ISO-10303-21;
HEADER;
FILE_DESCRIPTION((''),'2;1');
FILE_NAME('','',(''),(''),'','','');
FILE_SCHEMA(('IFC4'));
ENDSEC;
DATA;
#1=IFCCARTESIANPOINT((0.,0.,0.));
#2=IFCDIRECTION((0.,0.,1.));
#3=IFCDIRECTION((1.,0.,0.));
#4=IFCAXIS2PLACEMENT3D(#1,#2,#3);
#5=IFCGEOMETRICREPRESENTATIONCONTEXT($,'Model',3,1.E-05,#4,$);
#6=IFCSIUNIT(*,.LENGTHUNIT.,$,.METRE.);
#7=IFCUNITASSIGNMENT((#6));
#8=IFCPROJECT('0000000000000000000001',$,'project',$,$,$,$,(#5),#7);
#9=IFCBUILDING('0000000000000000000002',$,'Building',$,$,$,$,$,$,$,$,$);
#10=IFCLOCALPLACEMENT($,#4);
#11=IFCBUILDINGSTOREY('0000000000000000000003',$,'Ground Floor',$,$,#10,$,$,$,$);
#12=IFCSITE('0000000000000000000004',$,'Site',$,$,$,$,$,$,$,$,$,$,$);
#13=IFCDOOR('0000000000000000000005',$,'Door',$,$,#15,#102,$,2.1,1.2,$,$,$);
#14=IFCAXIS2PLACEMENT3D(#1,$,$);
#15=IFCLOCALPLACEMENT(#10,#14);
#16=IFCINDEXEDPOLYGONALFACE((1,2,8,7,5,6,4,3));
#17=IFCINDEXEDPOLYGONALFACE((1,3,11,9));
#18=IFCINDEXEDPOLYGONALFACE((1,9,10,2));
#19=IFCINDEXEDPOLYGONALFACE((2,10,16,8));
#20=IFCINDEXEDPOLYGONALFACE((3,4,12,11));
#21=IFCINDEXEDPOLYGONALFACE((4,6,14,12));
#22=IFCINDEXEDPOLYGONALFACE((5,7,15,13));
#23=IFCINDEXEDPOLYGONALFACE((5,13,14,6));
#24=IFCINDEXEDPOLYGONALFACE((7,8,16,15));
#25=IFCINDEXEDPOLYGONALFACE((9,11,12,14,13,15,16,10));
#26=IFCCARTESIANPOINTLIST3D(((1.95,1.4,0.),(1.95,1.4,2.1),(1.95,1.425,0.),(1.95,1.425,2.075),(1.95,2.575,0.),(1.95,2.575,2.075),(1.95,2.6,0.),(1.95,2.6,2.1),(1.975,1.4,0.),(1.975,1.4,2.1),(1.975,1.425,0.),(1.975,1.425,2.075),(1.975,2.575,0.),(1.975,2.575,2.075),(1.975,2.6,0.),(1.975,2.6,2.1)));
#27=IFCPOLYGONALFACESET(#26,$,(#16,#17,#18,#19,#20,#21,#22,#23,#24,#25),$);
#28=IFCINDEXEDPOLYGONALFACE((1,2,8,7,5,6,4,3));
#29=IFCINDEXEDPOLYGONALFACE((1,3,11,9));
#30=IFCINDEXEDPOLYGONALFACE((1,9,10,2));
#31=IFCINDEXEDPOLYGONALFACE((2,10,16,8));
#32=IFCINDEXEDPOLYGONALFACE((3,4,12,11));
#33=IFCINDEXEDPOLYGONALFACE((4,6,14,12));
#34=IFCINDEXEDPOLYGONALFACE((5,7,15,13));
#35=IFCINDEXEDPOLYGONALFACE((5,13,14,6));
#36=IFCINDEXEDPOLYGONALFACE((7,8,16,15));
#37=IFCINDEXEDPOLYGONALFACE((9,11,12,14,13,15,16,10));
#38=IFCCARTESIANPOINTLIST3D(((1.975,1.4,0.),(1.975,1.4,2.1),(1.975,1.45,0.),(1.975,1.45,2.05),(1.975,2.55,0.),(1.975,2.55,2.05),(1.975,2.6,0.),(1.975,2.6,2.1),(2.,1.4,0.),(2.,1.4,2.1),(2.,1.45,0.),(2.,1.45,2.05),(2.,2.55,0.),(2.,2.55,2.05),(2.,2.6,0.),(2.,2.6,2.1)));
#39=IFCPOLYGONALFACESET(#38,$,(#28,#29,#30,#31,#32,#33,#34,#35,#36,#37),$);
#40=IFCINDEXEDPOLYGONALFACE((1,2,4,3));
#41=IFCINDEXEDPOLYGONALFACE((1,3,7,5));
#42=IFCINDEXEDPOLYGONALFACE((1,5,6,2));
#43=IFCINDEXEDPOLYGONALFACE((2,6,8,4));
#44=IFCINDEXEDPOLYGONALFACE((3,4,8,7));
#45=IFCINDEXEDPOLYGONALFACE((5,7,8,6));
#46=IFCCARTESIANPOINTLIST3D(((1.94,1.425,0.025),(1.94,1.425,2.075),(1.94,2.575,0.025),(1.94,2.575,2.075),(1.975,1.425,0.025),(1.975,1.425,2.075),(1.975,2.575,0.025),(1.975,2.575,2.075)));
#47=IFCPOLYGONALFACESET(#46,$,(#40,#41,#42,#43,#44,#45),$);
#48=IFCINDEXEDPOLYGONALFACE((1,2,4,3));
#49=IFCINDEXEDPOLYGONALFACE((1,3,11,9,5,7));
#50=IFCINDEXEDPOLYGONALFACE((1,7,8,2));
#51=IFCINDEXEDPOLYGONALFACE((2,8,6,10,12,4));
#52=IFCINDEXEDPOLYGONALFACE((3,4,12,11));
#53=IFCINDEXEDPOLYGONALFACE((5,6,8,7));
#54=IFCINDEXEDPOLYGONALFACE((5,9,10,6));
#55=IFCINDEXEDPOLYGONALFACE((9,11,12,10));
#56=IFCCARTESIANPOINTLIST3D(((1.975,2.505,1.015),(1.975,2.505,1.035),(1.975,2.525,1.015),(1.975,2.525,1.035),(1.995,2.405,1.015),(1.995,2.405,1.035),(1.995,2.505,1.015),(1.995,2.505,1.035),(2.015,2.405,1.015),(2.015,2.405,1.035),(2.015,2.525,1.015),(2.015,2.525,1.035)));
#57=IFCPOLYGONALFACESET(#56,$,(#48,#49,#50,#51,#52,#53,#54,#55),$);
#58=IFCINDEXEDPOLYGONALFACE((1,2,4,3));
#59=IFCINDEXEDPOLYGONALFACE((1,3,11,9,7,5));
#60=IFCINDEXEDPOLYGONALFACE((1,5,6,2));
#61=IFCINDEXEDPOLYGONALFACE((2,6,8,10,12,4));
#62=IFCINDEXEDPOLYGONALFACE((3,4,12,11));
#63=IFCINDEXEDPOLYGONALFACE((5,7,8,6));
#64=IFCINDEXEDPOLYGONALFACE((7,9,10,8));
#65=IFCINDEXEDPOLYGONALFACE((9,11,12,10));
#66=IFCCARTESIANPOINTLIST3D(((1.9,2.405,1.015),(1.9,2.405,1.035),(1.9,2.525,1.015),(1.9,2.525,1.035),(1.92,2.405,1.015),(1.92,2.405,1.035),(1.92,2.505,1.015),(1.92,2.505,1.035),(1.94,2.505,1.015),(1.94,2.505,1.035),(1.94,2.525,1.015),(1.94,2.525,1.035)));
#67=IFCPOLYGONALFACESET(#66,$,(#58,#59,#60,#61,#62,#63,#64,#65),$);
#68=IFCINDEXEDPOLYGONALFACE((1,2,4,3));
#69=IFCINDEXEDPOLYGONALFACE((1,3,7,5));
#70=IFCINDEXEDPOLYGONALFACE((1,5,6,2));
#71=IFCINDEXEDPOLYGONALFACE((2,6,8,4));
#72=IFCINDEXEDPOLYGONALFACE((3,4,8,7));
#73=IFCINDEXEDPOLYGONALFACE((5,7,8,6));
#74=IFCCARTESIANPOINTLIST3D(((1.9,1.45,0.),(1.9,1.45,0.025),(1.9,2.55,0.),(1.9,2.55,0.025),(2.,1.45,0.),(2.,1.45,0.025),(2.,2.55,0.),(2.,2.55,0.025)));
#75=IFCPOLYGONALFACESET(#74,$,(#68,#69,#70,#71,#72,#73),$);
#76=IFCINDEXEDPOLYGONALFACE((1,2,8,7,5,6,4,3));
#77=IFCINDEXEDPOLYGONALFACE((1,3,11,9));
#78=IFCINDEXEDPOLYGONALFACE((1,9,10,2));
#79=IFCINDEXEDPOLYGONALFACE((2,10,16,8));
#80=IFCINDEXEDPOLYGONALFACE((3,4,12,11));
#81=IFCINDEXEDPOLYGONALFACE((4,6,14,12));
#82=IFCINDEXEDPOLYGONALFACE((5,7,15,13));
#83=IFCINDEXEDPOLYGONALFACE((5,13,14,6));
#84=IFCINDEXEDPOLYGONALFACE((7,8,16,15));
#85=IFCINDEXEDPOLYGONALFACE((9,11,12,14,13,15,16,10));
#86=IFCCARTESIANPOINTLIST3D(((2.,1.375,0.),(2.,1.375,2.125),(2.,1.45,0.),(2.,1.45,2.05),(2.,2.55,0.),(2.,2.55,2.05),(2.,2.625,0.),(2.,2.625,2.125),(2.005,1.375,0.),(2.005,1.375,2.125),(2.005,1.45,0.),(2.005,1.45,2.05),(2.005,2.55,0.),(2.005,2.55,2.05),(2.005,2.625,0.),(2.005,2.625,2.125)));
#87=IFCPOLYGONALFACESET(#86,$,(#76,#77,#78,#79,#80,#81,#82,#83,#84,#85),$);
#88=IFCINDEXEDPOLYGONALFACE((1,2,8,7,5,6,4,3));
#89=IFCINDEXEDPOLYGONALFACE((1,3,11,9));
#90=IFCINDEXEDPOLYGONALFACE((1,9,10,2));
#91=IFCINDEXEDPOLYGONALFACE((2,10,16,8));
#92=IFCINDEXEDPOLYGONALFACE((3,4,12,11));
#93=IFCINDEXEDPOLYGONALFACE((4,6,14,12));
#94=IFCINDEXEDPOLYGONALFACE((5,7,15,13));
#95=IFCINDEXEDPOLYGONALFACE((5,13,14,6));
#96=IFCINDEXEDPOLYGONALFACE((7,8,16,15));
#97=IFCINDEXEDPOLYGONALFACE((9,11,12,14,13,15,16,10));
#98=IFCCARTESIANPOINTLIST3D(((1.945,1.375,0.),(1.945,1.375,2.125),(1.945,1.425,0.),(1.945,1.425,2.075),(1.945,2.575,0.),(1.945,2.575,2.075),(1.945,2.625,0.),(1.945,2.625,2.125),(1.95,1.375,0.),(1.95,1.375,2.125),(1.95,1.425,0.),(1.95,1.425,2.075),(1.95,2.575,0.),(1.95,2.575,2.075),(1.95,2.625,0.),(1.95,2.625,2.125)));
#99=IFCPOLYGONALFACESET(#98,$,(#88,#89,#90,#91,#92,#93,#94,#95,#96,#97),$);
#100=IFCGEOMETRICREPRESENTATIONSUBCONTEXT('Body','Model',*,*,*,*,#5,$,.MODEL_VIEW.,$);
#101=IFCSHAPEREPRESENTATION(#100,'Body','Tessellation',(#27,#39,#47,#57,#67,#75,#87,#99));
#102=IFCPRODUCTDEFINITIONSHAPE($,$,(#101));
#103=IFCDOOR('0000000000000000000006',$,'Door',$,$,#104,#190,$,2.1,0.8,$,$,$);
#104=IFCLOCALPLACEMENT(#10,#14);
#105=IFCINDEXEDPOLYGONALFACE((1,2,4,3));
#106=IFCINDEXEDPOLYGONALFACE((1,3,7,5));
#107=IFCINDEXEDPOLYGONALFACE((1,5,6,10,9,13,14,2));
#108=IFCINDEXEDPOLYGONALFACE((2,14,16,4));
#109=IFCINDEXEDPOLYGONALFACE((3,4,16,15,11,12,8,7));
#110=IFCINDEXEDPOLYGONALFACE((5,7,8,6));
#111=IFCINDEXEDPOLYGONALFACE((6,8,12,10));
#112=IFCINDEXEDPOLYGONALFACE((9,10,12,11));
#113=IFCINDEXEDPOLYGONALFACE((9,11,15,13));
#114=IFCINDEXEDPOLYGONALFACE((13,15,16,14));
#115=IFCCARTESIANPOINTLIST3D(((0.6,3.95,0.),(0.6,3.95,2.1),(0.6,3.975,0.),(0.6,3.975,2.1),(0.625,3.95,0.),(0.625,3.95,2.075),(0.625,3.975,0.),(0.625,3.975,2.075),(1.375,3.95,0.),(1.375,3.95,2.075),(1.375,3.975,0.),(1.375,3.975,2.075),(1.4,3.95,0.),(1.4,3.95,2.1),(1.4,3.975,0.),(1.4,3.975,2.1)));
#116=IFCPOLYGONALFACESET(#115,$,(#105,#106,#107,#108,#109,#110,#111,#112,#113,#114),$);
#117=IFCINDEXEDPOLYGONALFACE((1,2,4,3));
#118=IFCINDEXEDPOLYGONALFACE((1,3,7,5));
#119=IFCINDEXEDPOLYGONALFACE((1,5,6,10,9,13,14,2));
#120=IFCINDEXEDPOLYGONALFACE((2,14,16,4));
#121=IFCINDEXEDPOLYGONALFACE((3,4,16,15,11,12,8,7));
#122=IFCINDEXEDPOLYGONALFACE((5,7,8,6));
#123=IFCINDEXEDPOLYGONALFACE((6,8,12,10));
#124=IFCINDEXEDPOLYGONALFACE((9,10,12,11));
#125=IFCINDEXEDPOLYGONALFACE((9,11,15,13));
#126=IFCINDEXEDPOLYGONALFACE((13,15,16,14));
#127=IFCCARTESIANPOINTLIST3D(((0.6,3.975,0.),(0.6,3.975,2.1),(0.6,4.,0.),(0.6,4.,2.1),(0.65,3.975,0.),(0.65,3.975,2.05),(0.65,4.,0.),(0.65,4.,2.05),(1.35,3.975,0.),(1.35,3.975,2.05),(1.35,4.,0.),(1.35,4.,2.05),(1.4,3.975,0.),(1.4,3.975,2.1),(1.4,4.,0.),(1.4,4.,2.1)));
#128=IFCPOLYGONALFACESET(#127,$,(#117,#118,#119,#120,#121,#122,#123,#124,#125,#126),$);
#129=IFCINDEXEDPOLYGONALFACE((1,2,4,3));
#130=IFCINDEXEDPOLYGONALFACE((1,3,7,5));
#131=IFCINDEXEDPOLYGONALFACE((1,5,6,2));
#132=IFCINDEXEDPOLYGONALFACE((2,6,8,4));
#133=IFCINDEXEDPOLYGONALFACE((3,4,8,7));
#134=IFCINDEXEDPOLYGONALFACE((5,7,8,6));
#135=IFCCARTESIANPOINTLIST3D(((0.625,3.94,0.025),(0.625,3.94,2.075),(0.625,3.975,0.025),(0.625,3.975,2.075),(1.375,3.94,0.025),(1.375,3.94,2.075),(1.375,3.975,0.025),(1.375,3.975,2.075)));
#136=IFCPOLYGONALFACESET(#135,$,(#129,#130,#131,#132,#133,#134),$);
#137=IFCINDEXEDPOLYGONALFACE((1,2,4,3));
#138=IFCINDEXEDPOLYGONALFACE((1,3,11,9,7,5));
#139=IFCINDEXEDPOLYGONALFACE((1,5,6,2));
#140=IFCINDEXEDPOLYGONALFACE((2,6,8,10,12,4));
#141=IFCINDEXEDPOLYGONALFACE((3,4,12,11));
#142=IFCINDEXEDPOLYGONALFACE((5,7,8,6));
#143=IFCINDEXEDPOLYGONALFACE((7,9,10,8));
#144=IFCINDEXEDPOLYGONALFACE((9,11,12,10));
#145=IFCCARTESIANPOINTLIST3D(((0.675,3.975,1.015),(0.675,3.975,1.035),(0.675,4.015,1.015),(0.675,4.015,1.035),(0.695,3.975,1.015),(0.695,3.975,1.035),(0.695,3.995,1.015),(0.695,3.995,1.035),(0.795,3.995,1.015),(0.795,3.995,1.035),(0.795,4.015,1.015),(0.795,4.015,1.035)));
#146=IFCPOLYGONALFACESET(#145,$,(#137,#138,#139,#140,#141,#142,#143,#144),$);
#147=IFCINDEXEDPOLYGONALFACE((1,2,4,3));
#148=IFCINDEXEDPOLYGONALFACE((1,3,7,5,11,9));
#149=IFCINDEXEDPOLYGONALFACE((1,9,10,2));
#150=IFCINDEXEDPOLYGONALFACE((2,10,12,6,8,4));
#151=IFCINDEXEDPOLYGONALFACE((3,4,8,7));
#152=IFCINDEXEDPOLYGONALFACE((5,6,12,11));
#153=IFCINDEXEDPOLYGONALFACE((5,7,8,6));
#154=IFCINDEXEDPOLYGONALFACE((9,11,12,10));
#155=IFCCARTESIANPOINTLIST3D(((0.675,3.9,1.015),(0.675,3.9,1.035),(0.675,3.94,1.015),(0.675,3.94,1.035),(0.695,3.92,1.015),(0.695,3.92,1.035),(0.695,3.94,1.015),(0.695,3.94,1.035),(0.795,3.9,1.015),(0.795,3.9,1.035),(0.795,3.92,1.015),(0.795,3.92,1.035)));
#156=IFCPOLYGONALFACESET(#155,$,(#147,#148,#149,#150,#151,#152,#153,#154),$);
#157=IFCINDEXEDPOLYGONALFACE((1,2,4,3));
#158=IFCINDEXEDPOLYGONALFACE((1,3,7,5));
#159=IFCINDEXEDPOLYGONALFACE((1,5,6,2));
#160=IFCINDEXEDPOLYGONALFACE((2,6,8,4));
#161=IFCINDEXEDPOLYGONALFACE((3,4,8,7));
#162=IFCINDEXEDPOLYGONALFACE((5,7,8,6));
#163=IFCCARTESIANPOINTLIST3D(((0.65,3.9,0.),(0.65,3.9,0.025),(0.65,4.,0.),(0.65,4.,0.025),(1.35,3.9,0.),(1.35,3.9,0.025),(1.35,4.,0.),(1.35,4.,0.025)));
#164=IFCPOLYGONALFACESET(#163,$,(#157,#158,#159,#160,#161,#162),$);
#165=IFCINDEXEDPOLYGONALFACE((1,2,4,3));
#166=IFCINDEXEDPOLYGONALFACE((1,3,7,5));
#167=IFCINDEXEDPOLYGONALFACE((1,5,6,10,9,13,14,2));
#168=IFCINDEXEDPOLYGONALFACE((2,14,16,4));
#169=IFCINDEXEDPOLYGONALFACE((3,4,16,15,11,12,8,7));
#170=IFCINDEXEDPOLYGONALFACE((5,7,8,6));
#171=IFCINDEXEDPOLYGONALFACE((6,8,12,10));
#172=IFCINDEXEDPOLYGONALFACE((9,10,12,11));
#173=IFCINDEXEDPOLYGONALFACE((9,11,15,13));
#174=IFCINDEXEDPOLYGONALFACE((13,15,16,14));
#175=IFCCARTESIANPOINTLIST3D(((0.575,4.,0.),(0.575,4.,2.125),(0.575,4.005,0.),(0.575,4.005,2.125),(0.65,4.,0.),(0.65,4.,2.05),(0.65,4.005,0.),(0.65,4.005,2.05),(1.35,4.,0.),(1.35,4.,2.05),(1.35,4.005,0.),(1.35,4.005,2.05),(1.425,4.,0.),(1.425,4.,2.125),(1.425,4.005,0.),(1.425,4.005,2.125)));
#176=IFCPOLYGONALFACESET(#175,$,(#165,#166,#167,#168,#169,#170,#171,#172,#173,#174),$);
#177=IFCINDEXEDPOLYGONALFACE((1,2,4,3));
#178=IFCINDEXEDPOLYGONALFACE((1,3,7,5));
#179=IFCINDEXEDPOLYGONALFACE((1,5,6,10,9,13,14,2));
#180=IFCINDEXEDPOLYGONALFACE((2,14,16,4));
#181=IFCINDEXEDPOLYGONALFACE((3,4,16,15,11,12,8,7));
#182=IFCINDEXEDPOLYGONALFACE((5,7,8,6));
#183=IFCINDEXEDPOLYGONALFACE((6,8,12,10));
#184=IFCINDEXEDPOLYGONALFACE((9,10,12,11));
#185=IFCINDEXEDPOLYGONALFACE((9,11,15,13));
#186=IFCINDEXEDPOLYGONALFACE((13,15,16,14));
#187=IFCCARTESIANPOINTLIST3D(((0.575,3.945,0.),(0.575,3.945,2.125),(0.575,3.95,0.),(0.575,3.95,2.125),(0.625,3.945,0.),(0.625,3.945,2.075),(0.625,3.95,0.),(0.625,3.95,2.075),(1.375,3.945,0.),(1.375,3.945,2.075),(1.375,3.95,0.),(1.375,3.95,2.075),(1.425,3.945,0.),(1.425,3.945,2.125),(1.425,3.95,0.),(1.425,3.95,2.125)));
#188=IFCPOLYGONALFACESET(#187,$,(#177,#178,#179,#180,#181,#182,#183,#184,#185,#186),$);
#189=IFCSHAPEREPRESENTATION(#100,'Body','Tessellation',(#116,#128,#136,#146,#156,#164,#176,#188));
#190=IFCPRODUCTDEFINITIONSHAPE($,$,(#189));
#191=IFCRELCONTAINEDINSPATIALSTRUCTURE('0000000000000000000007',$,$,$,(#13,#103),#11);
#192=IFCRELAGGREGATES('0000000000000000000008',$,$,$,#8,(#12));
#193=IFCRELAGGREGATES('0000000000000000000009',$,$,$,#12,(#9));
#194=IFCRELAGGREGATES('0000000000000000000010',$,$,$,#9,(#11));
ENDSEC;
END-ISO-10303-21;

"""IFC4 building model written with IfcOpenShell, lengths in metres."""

from ifc_helpers import new_model, si_unit, frame, origin_with_axes, place, context, subcontext, project, spatial, line, indexed_curve, outline, extrude, element, save


model = new_model("IFC4")

# Units and contexts
model_context = context("Model", 3, precision=1e-05, world=origin_with_axes())
body_context = subcontext(model_context, "Body", "Model", "MODEL_VIEW")
ifc_project = project(units=[si_unit("LENGTHUNIT", "METRE")], contexts=[model_context])

# Site, building, storey
site = spatial("IfcSite", under=ifc_project, Name="Site")
building = spatial("IfcBuilding", under=site, Name="Building")
storey_placement = place(None, origin_with_axes())
storey = spatial("IfcBuildingStorey", under=building, at=storey_placement, Name="Ground Floor")

# Doors
door_1_placement = place(storey_placement, frame((2.0, 1.4, 0.0), z_axis=(0.0, 0.0, 1.0), x_axis=(0.0, 1.0, 0.0)))
element("IfcDoor", 1, at=door_1_placement, inside=storey, Name="Door", OverallHeight=2.1, OverallWidth=1.2, context=body_context, shape_type="SweptSolid", body=[
    extrude(outline(indexed_curve([(0.0, 0.0), (0.0, 2.1), (1.2, 2.1), (1.2, 0.0), (1.175, 0.0), (1.175, 2.075), (0.025, 2.075), (0.025, 0.0)], segments=[line(1, 2, 3, 4, 5, 6, 7, 8, 1)])), frame((0.0, 0.025, 0.0), z_axis=(0.0, -1.0, 0.0), x_axis=(1.0, 0.0, 0.0)), (0.0, 0.0, -1.0), 0.025),
    extrude(outline(indexed_curve([(0.0, 0.0), (0.0, 2.1), (1.2, 2.1), (1.2, 0.0), (1.15, 0.0), (1.15, 2.05), (0.05, 2.05), (0.05, 0.0)], segments=[line(1, 2, 3, 4, 5, 6, 7, 8, 1)])), frame((0.0, 0.0, 0.0), z_axis=(0.0, -1.0, 0.0), x_axis=(1.0, 0.0, 0.0)), (0.0, 0.0, -1.0), 0.025),
    extrude(outline(indexed_curve([(0.0, 0.0), (1.15, 0.0), (1.15, 0.035), (0.0, 0.035)], segments=[line(1, 2, 3, 4, 1)])), frame((0.025, 0.025, 0.025), z_axis=(0.0, 0.0, 1.0), x_axis=(1.0, 0.0, 0.0)), (0.0, 0.0, 1.0), 2.05),
    extrude(outline(indexed_curve([(0.0, 0.0), (0.0, -0.04), (-0.12, -0.04), (-0.12, -0.02), (-0.02, -0.02), (-0.02, 0.0)], segments=[line(1, 2, 3, 4, 5, 6, 1)])), frame((1.125, 0.025, 1.015), z_axis=(0.0, 0.0, 1.0), x_axis=(1.0, 0.0, 0.0)), (0.0, 0.0, 1.0), 0.02),
    extrude(outline(indexed_curve([(0.0, 0.0), (0.0, 0.04), (-0.12, 0.04), (-0.12, 0.02), (-0.02, 0.02), (-0.02, 0.0)], segments=[line(1, 2, 3, 4, 5, 6, 1)])), frame((1.125, 0.06, 1.015), z_axis=(0.0, 0.0, 1.0), x_axis=(1.0, 0.0, 0.0)), (0.0, 0.0, 1.0), 0.02),
    extrude(outline(indexed_curve([(0.0, 0.0), (1.1, 0.0), (1.1, 0.1), (0.0, 0.1)], segments=[line(1, 2, 3, 4, 1)])), frame((0.05, 0.0, 0.0), z_axis=(0.0, 0.0, 1.0), x_axis=(1.0, 0.0, 0.0)), (0.0, 0.0, 1.0), 0.025),
    extrude(outline(indexed_curve([(0.0, 0.0), (0.0, 2.125), (1.25, 2.125), (1.25, 0.0), (1.175, 0.0), (1.175, 2.05), (0.075, 2.05), (0.075, 0.0)], segments=[line(1, 2, 3, 4, 5, 6, 7, 8, 1)])), frame((-0.025, -0.005, 0.0), z_axis=(0.0, -1.0, 0.0), x_axis=(1.0, 0.0, 0.0)), (0.0, 0.0, -1.0), 0.005),
    extrude(outline(indexed_curve([(0.0, 0.0), (0.0, 2.125), (1.25, 2.125), (1.25, 0.0), (1.2, 0.0), (1.2, 2.075), (0.05, 2.075), (0.05, 0.0)], segments=[line(1, 2, 3, 4, 5, 6, 7, 8, 1)])), frame((-0.025, 0.05, 0.0), z_axis=(0.0, -1.0, 0.0), x_axis=(1.0, 0.0, 0.0)), (0.0, 0.0, -1.0), 0.005),
])
door_2_placement = place(storey_placement, frame((1.4, 4.0, 0.0), z_axis=(0.0, 0.0, 1.0), x_axis=(-1.0, 0.0, 0.0)))
element("IfcDoor", 2, at=door_2_placement, inside=storey, Name="Door", OverallHeight=2.1, OverallWidth=0.8, context=body_context, shape_type="SweptSolid", body=[
    extrude(outline(indexed_curve([(0.0, 0.0), (0.0, 2.1), (0.8, 2.1), (0.8, 0.0), (0.775, 0.0), (0.775, 2.075), (0.025, 2.075), (0.025, 0.0)], segments=[line(1, 2, 3, 4, 5, 6, 7, 8, 1)])), frame((0.0, 0.025, 0.0), z_axis=(0.0, -1.0, 0.0), x_axis=(1.0, 0.0, 0.0)), (0.0, 0.0, -1.0), 0.025),
    extrude(outline(indexed_curve([(0.0, 0.0), (0.0, 2.1), (0.8, 2.1), (0.8, 0.0), (0.75, 0.0), (0.75, 2.05), (0.05, 2.05), (0.05, 0.0)], segments=[line(1, 2, 3, 4, 5, 6, 7, 8, 1)])), frame((0.0, 0.0, 0.0), z_axis=(0.0, -1.0, 0.0), x_axis=(1.0, 0.0, 0.0)), (0.0, 0.0, -1.0), 0.025),
    extrude(outline(indexed_curve([(0.0, 0.0), (0.75, 0.0), (0.75, 0.035), (0.0, 0.035)], segments=[line(1, 2, 3, 4, 1)])), frame((0.025, 0.025, 0.025), z_axis=(0.0, 0.0, 1.0), x_axis=(1.0, 0.0, 0.0)), (0.0, 0.0, 1.0), 2.05),
    extrude(outline(indexed_curve([(0.0, 0.0), (0.0, -0.04), (-0.12, -0.04), (-0.12, -0.02), (-0.02, -0.02), (-0.02, 0.0)], segments=[line(1, 2, 3, 4, 5, 6, 1)])), frame((0.725, 0.025, 1.015), z_axis=(0.0, 0.0, 1.0), x_axis=(1.0, 0.0, 0.0)), (0.0, 0.0, 1.0), 0.02),
    extrude(outline(indexed_curve([(0.0, 0.0), (0.0, 0.04), (-0.12, 0.04), (-0.12, 0.02), (-0.02, 0.02), (-0.02, 0.0)], segments=[line(1, 2, 3, 4, 5, 6, 1)])), frame((0.725, 0.06, 1.015), z_axis=(0.0, 0.0, 1.0), x_axis=(1.0, 0.0, 0.0)), (0.0, 0.0, 1.0), 0.02),
    extrude(outline(indexed_curve([(0.0, 0.0), (0.7, 0.0), (0.7, 0.1), (0.0, 0.1)], segments=[line(1, 2, 3, 4, 1)])), frame((0.05, 0.0, 0.0), z_axis=(0.0, 0.0, 1.0), x_axis=(1.0, 0.0, 0.0)), (0.0, 0.0, 1.0), 0.025),
    extrude(outline(indexed_curve([(0.0, 0.0), (0.0, 2.125), (0.85, 2.125), (0.85, 0.0), (0.775, 0.0), (0.775, 2.05), (0.075, 2.05), (0.075, 0.0)], segments=[line(1, 2, 3, 4, 5, 6, 7, 8, 1)])), frame((-0.025, -0.005, 0.0), z_axis=(0.0, -1.0, 0.0), x_axis=(1.0, 0.0, 0.0)), (0.0, 0.0, -1.0), 0.005),
    extrude(outline(indexed_curve([(0.0, 0.0), (0.0, 2.125), (0.85, 2.125), (0.85, 0.0), (0.8, 0.0), (0.8, 2.075), (0.05, 2.075), (0.05, 0.0)], segments=[line(1, 2, 3, 4, 5, 6, 7, 8, 1)])), frame((-0.025, 0.05, 0.0), z_axis=(0.0, -1.0, 0.0), x_axis=(1.0, 0.0, 0.0)), (0.0, 0.0, -1.0), 0.005),
])

save(model, "model.ifc")
